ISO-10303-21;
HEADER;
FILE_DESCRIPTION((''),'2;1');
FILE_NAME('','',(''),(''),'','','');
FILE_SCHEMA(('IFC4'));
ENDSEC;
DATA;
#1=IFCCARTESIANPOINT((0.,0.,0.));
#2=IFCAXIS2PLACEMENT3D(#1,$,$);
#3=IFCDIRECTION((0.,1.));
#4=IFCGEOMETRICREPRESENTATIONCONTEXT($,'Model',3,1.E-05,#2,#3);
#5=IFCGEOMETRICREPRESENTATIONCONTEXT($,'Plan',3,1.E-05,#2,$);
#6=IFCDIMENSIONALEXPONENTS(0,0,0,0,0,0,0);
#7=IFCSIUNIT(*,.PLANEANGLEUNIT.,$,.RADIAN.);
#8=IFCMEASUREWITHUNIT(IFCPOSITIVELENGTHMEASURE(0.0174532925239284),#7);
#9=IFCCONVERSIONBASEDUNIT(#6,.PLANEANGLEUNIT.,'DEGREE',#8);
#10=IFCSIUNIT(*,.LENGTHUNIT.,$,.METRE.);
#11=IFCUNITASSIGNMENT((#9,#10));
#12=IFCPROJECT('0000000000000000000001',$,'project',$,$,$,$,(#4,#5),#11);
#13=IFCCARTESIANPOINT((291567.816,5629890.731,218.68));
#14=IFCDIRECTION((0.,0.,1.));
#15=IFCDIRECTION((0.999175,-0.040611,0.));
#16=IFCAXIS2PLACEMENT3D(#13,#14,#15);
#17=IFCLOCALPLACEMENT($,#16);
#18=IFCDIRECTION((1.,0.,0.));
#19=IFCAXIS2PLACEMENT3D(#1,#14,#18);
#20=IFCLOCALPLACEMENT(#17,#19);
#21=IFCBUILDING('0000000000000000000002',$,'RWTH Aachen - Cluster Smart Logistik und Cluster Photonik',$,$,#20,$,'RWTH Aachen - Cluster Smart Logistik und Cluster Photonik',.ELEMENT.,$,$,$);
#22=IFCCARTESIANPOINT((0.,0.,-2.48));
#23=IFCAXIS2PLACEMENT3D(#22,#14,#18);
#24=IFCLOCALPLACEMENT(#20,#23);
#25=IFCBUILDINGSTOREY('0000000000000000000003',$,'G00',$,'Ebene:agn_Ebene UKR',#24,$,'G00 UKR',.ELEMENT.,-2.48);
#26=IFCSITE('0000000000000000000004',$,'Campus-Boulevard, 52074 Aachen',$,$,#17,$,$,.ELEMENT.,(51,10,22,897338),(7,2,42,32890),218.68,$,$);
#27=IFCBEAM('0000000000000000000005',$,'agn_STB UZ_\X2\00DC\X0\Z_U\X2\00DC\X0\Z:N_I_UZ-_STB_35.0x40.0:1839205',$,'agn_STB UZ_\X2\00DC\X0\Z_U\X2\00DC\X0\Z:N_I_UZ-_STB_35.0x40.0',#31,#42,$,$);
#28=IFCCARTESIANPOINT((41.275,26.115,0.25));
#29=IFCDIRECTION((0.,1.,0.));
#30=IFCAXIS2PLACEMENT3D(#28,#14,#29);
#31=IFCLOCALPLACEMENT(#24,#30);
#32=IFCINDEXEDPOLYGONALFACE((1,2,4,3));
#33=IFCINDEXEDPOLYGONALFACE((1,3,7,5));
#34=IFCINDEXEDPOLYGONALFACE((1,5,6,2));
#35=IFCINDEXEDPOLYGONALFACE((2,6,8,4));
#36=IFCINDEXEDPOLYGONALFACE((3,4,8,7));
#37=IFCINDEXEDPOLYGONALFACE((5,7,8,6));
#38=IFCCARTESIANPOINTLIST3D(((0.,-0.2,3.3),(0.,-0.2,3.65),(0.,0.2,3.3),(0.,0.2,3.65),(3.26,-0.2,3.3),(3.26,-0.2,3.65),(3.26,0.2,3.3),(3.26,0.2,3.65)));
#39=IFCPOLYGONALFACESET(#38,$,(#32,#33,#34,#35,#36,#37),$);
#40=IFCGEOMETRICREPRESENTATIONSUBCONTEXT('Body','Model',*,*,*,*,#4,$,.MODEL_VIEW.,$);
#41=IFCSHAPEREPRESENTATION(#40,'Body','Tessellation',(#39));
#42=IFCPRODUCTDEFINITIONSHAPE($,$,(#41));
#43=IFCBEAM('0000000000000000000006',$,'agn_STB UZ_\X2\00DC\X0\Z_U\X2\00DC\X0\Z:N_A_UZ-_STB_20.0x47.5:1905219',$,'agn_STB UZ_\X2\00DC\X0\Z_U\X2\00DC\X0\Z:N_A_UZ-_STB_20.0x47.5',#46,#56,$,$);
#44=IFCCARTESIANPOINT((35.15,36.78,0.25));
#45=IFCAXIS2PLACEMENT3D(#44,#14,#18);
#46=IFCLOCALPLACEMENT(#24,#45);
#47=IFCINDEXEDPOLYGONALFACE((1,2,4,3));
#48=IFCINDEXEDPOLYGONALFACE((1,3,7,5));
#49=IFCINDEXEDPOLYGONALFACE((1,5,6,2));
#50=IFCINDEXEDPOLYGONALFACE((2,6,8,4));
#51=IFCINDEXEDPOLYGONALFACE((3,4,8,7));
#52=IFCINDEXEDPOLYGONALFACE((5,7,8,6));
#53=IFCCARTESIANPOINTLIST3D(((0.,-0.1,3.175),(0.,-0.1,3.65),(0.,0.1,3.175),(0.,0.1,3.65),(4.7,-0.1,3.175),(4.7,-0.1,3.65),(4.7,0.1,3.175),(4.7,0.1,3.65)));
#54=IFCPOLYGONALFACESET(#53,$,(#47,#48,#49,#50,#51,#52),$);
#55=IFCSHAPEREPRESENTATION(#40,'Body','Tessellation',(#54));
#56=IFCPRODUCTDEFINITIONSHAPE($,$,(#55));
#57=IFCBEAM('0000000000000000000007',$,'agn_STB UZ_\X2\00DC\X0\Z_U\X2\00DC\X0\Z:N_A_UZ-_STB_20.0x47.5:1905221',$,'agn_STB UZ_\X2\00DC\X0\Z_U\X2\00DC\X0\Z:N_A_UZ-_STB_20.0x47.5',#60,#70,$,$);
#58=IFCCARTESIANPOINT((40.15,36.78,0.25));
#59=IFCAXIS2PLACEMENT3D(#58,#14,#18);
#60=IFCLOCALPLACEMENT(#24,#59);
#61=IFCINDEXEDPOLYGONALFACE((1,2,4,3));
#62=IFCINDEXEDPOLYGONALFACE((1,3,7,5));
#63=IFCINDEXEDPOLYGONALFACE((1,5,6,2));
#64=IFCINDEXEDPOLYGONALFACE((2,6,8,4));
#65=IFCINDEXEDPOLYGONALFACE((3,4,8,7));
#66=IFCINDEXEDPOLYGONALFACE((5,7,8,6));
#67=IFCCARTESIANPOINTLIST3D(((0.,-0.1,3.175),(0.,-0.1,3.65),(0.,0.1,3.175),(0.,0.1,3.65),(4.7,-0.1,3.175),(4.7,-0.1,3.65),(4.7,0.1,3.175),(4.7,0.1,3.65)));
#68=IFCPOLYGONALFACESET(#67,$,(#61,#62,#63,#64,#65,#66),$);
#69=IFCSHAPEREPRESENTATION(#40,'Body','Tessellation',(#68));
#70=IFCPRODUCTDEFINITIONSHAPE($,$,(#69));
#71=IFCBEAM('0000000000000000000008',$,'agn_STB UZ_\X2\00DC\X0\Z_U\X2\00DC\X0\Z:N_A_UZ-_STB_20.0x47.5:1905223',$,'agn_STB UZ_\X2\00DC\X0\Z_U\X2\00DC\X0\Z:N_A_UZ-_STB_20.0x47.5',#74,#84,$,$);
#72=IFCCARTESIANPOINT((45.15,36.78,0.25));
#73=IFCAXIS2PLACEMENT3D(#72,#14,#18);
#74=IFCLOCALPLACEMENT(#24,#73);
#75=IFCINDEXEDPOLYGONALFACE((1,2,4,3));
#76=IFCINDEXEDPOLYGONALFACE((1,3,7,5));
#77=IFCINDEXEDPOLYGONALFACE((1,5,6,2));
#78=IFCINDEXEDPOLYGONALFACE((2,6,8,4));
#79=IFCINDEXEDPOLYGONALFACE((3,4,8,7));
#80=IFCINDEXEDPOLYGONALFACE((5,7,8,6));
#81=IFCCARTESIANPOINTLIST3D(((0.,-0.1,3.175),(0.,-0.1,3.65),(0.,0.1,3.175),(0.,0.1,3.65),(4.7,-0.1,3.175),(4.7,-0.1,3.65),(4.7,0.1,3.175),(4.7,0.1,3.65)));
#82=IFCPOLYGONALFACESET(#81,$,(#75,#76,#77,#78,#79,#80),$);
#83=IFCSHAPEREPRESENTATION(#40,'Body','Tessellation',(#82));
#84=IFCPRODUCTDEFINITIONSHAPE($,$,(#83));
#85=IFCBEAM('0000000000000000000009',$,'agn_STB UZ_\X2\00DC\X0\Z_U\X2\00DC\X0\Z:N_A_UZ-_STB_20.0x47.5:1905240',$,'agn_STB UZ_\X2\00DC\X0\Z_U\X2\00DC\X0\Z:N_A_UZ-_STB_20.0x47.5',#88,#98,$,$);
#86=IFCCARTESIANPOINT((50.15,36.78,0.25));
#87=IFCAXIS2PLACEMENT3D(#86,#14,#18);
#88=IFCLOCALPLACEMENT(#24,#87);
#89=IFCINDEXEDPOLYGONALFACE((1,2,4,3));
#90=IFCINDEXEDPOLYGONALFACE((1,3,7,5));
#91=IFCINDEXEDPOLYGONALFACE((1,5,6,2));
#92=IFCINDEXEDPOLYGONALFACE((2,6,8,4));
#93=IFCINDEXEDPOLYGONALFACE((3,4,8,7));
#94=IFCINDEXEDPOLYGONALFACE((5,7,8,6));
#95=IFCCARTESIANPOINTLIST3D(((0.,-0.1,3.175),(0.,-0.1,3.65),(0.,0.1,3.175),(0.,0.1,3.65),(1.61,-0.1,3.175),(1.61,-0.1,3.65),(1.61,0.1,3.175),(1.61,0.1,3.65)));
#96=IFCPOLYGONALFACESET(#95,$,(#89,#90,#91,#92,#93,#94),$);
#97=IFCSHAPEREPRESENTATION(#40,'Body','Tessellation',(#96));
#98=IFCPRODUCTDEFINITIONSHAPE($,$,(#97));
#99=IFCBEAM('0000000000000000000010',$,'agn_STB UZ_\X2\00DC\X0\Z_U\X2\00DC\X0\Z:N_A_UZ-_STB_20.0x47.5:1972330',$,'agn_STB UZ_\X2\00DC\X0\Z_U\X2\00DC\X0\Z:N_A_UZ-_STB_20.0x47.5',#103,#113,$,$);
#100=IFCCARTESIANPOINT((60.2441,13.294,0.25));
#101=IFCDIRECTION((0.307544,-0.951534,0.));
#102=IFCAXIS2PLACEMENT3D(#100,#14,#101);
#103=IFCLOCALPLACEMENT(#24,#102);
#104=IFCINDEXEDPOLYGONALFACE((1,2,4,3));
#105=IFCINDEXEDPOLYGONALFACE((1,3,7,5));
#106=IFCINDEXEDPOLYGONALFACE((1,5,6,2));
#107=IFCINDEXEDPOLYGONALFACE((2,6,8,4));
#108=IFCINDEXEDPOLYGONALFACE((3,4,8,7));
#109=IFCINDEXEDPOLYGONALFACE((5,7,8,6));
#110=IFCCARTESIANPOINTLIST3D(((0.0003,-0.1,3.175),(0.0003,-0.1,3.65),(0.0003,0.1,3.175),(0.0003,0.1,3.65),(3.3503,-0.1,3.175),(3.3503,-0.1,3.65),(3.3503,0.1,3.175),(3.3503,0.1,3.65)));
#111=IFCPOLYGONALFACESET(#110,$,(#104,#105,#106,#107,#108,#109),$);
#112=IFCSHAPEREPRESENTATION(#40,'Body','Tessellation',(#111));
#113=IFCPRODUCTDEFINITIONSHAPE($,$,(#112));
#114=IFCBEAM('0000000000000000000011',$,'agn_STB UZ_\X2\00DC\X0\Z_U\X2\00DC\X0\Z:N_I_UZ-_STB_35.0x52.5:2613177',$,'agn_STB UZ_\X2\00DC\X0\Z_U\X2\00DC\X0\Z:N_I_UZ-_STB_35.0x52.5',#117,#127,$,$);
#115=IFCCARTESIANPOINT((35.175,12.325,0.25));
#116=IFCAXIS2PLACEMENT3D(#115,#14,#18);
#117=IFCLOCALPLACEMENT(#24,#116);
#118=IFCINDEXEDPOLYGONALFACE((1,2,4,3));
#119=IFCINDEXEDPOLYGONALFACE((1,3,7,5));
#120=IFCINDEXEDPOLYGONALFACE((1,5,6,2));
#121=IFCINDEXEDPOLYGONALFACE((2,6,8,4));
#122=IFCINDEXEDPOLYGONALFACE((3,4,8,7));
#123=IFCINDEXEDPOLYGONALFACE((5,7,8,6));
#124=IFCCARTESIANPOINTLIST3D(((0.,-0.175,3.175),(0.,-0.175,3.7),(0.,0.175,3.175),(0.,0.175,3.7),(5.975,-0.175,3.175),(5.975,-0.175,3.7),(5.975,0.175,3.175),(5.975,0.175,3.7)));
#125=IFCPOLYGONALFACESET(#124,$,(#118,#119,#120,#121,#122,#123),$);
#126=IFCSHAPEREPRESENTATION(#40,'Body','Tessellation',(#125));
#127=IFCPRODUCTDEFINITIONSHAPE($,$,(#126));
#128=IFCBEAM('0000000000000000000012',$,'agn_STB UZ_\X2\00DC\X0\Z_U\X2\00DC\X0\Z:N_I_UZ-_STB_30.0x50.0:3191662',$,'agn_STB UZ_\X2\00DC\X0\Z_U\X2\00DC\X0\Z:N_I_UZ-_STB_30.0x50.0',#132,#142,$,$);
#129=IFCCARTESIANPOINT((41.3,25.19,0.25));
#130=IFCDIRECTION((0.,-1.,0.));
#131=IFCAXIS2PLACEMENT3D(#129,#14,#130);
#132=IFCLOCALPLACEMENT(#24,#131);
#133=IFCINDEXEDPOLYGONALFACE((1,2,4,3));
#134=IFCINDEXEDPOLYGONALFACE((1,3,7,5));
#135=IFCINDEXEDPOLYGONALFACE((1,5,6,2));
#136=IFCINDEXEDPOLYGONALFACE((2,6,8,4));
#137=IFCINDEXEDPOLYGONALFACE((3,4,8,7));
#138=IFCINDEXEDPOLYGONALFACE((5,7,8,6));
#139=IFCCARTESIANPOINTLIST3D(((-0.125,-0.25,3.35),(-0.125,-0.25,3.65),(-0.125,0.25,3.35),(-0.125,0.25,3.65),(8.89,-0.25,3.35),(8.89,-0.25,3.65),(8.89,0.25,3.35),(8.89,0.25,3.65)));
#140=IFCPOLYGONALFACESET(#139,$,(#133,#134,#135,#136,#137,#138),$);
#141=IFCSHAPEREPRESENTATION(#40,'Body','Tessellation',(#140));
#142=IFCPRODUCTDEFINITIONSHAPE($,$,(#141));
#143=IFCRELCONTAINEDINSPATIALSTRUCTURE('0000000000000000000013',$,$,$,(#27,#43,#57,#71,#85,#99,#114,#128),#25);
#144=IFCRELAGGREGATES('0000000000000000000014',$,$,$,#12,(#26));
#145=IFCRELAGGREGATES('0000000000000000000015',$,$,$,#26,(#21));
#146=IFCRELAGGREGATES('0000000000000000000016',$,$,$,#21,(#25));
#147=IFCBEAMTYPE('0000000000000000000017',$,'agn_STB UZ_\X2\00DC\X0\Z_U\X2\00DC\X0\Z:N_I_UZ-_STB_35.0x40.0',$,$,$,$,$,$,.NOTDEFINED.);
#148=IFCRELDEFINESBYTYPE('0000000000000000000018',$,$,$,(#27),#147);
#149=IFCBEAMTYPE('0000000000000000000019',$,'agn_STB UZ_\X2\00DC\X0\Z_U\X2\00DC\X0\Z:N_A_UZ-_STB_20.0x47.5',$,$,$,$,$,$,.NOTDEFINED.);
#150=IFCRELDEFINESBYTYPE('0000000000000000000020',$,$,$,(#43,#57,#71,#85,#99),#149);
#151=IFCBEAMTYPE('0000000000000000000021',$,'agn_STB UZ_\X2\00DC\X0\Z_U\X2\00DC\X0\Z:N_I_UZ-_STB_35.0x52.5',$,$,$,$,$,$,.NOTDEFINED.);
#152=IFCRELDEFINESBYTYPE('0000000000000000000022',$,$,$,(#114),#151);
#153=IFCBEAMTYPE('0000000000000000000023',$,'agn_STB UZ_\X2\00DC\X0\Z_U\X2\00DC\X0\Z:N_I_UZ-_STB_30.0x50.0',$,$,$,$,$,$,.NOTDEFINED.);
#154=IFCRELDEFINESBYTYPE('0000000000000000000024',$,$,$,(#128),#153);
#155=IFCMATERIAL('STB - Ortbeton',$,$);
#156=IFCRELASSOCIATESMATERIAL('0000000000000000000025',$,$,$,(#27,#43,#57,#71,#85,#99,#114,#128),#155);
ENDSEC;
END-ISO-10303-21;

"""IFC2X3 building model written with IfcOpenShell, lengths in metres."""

from ifc_helpers import new_model, entity, si_unit, converted_unit, direction, frame, frame_2d, origin, origin_with_axes, place, context, subcontext, project, spatial, rectangle, extrude, material, type_object, element, save


model = new_model("IFC2X3")

# Units and contexts
model_context = context("Model", 3, precision=1e-05, world=origin(), true_north=direction((0.0, 1.0)))
plan_context = context("Plan", 3, precision=1e-05, world=origin())
body_context = subcontext(model_context, "Body", "Model", "MODEL_VIEW")
ifc_project = project(units=[converted_unit("PLANEANGLEUNIT", "DEGREE", entity("IfcPositiveLengthMeasure", 0.0174532925239284), si_unit("PLANEANGLEUNIT", "RADIAN"), dimensions=[0, 0, 0, 0, 0, 0, 0]), si_unit("LENGTHUNIT", "METRE")], contexts=[model_context, plan_context])

# Site, building, storey
site_placement = place(None, frame((291567.816, 5629890.731, 218.68), z_axis=(0.0, 0.0, 1.0), x_axis=(0.999175, -0.040611, 0.0)))
site = spatial("IfcSite", under=ifc_project, at=site_placement, Name="Campus-Boulevard, 52074 Aachen", CompositionType="ELEMENT", RefLatitude=(51, 10, 22, 897338), RefLongitude=(7, 2, 42, 32890), RefElevation=218.68)
building_placement = place(site_placement, origin_with_axes())
building = spatial("IfcBuilding", under=site, at=building_placement, Name="RWTH Aachen - Cluster Smart Logistik und Cluster Photonik", LongName="RWTH Aachen - Cluster Smart Logistik und Cluster Photonik", CompositionType="ELEMENT")
storey_placement = place(building_placement, frame((0.0, 0.0, -2.48), z_axis=(0.0, 0.0, 1.0), x_axis=(1.0, 0.0, 0.0)))
storey = spatial("IfcBuildingStorey", under=building, at=storey_placement, Name="G00", ObjectType="Ebene:agn_Ebene UKR", LongName="G00 UKR", CompositionType="ELEMENT", Elevation=-2.48)

# Beams
ifc_material_1 = material(Name="STB - Ortbeton")
beam_type_1 = type_object("IfcBeamType", Name="agn_STB UZ_ÜZ_UÜZ:N_I_UZ-_STB_35.0x40.0", PredefinedType="NOTDEFINED")
beam_1_placement = place(storey_placement, frame((41.275, 26.115, 0.25), z_axis=(0.0, 0.0, 1.0), x_axis=(0.0, 1.0, 0.0)))
element("IfcBeam", 1, at=beam_1_placement, inside=storey, type_object=beam_type_1, material=ifc_material_1, Name="agn_STB UZ_ÜZ_UÜZ:N_I_UZ-_STB_35.0x40.0:1839205", ObjectType="agn_STB UZ_ÜZ_UÜZ:N_I_UZ-_STB_35.0x40.0", context=body_context, shape_type="SweptSolid", body=[
    extrude(rectangle(XDim=0.35, YDim=0.4, at=frame_2d((0.0, 0.0), x_axis=(1.0, 0.0))), frame((0.0, 0.0, 3.475), z_axis=(1.0, 0.0, 0.0), x_axis=(0.0, 0.0, -1.0)), (0.0, 0.0, 1.0), 3.26),
])
beam_type_2 = type_object("IfcBeamType", Name="agn_STB UZ_ÜZ_UÜZ:N_A_UZ-_STB_20.0x47.5", PredefinedType="NOTDEFINED")
for number, where, z_axis, x_axis, name in (
    (2, (35.15, 36.78, 0.25), (0.0, 0.0, 1.0), (1.0, 0.0, 0.0), "agn_STB UZ_ÜZ_UÜZ:N_A_UZ-_STB_20.0x47.5:1905219"),
    (3, (40.15, 36.78, 0.25), (0.0, 0.0, 1.0), (1.0, 0.0, 0.0), "agn_STB UZ_ÜZ_UÜZ:N_A_UZ-_STB_20.0x47.5:1905221"),
    (4, (45.15, 36.78, 0.25), (0.0, 0.0, 1.0), (1.0, 0.0, 0.0), "agn_STB UZ_ÜZ_UÜZ:N_A_UZ-_STB_20.0x47.5:1905223"),
):
    element("IfcBeam", number, at=place(storey_placement, frame(where, z_axis=z_axis, x_axis=x_axis)), inside=storey, type_object=beam_type_2, material=ifc_material_1, Name=name, ObjectType="agn_STB UZ_ÜZ_UÜZ:N_A_UZ-_STB_20.0x47.5", context=body_context, shape_type="SweptSolid", body=[
        extrude(rectangle(XDim=0.475, YDim=0.2, at=frame_2d((0.0, 0.0), x_axis=(1.0, 0.0))), frame((0.0, 0.0, 3.4125), z_axis=(1.0, 0.0, 0.0), x_axis=(0.0, 0.0, -1.0)), (0.0, 0.0, 1.0), 4.7),
    ])
beam_2_placement = place(storey_placement, frame((50.15, 36.78, 0.25), z_axis=(0.0, 0.0, 1.0), x_axis=(1.0, 0.0, 0.0)))
element("IfcBeam", 5, at=beam_2_placement, inside=storey, type_object=beam_type_2, material=ifc_material_1, Name="agn_STB UZ_ÜZ_UÜZ:N_A_UZ-_STB_20.0x47.5:1905240", ObjectType="agn_STB UZ_ÜZ_UÜZ:N_A_UZ-_STB_20.0x47.5", context=body_context, shape_type="SweptSolid", body=[
    extrude(rectangle(XDim=0.475, YDim=0.2, at=frame_2d((0.0, 0.0), x_axis=(1.0, 0.0))), frame((0.0, 0.0, 3.4125), z_axis=(1.0, 0.0, 0.0), x_axis=(0.0, 0.0, -1.0)), (0.0, 0.0, 1.0), 1.61),
])
beam_3_placement = place(storey_placement, frame((60.2441, 13.294, 0.25), z_axis=(0.0, 0.0, 1.0), x_axis=(0.307544, -0.951534, 0.0)))
element("IfcBeam", 6, at=beam_3_placement, inside=storey, type_object=beam_type_2, material=ifc_material_1, Name="agn_STB UZ_ÜZ_UÜZ:N_A_UZ-_STB_20.0x47.5:1972330", ObjectType="agn_STB UZ_ÜZ_UÜZ:N_A_UZ-_STB_20.0x47.5", context=body_context, shape_type="SweptSolid", body=[
    extrude(rectangle(XDim=0.475, YDim=0.2, at=frame_2d((0.0, 0.0), x_axis=(1.0, 0.0))), frame((0.0003, 0.0, 3.4125), z_axis=(1.0, 0.0, 0.0), x_axis=(0.0, 0.0, -1.0)), (0.0, 0.0, 1.0), 3.35),
])
beam_type_3 = type_object("IfcBeamType", Name="agn_STB UZ_ÜZ_UÜZ:N_I_UZ-_STB_35.0x52.5", PredefinedType="NOTDEFINED")
beam_4_placement = place(storey_placement, frame((35.175, 12.325, 0.25), z_axis=(0.0, 0.0, 1.0), x_axis=(1.0, 0.0, 0.0)))
element("IfcBeam", 7, at=beam_4_placement, inside=storey, type_object=beam_type_3, material=ifc_material_1, Name="agn_STB UZ_ÜZ_UÜZ:N_I_UZ-_STB_35.0x52.5:2613177", ObjectType="agn_STB UZ_ÜZ_UÜZ:N_I_UZ-_STB_35.0x52.5", context=body_context, shape_type="SweptSolid", body=[
    extrude(rectangle(XDim=0.525, YDim=0.35, at=frame_2d((0.0, 0.0), x_axis=(1.0, 0.0))), frame((0.0, 0.0, 3.4375), z_axis=(1.0, 0.0, 0.0), x_axis=(0.0, 0.0, -1.0)), (0.0, 0.0, 1.0), 5.975),
])
beam_type_4 = type_object("IfcBeamType", Name="agn_STB UZ_ÜZ_UÜZ:N_I_UZ-_STB_30.0x50.0", PredefinedType="NOTDEFINED")
beam_5_placement = place(storey_placement, frame((41.3, 25.19, 0.25), z_axis=(0.0, 0.0, 1.0), x_axis=(0.0, -1.0, 0.0)))
element("IfcBeam", 8, at=beam_5_placement, inside=storey, type_object=beam_type_4, material=ifc_material_1, Name="agn_STB UZ_ÜZ_UÜZ:N_I_UZ-_STB_30.0x50.0:3191662", ObjectType="agn_STB UZ_ÜZ_UÜZ:N_I_UZ-_STB_30.0x50.0", context=body_context, shape_type="SweptSolid", body=[
    extrude(rectangle(XDim=0.3, YDim=0.5, at=frame_2d((0.0, 0.0), x_axis=(1.0, 0.0))), frame((-0.125, 0.0, 3.5), z_axis=(1.0, 0.0, 0.0), x_axis=(0.0, 0.0, -1.0)), (0.0, 0.0, 1.0), 9.015),
])

save(model, "model.ifc")
